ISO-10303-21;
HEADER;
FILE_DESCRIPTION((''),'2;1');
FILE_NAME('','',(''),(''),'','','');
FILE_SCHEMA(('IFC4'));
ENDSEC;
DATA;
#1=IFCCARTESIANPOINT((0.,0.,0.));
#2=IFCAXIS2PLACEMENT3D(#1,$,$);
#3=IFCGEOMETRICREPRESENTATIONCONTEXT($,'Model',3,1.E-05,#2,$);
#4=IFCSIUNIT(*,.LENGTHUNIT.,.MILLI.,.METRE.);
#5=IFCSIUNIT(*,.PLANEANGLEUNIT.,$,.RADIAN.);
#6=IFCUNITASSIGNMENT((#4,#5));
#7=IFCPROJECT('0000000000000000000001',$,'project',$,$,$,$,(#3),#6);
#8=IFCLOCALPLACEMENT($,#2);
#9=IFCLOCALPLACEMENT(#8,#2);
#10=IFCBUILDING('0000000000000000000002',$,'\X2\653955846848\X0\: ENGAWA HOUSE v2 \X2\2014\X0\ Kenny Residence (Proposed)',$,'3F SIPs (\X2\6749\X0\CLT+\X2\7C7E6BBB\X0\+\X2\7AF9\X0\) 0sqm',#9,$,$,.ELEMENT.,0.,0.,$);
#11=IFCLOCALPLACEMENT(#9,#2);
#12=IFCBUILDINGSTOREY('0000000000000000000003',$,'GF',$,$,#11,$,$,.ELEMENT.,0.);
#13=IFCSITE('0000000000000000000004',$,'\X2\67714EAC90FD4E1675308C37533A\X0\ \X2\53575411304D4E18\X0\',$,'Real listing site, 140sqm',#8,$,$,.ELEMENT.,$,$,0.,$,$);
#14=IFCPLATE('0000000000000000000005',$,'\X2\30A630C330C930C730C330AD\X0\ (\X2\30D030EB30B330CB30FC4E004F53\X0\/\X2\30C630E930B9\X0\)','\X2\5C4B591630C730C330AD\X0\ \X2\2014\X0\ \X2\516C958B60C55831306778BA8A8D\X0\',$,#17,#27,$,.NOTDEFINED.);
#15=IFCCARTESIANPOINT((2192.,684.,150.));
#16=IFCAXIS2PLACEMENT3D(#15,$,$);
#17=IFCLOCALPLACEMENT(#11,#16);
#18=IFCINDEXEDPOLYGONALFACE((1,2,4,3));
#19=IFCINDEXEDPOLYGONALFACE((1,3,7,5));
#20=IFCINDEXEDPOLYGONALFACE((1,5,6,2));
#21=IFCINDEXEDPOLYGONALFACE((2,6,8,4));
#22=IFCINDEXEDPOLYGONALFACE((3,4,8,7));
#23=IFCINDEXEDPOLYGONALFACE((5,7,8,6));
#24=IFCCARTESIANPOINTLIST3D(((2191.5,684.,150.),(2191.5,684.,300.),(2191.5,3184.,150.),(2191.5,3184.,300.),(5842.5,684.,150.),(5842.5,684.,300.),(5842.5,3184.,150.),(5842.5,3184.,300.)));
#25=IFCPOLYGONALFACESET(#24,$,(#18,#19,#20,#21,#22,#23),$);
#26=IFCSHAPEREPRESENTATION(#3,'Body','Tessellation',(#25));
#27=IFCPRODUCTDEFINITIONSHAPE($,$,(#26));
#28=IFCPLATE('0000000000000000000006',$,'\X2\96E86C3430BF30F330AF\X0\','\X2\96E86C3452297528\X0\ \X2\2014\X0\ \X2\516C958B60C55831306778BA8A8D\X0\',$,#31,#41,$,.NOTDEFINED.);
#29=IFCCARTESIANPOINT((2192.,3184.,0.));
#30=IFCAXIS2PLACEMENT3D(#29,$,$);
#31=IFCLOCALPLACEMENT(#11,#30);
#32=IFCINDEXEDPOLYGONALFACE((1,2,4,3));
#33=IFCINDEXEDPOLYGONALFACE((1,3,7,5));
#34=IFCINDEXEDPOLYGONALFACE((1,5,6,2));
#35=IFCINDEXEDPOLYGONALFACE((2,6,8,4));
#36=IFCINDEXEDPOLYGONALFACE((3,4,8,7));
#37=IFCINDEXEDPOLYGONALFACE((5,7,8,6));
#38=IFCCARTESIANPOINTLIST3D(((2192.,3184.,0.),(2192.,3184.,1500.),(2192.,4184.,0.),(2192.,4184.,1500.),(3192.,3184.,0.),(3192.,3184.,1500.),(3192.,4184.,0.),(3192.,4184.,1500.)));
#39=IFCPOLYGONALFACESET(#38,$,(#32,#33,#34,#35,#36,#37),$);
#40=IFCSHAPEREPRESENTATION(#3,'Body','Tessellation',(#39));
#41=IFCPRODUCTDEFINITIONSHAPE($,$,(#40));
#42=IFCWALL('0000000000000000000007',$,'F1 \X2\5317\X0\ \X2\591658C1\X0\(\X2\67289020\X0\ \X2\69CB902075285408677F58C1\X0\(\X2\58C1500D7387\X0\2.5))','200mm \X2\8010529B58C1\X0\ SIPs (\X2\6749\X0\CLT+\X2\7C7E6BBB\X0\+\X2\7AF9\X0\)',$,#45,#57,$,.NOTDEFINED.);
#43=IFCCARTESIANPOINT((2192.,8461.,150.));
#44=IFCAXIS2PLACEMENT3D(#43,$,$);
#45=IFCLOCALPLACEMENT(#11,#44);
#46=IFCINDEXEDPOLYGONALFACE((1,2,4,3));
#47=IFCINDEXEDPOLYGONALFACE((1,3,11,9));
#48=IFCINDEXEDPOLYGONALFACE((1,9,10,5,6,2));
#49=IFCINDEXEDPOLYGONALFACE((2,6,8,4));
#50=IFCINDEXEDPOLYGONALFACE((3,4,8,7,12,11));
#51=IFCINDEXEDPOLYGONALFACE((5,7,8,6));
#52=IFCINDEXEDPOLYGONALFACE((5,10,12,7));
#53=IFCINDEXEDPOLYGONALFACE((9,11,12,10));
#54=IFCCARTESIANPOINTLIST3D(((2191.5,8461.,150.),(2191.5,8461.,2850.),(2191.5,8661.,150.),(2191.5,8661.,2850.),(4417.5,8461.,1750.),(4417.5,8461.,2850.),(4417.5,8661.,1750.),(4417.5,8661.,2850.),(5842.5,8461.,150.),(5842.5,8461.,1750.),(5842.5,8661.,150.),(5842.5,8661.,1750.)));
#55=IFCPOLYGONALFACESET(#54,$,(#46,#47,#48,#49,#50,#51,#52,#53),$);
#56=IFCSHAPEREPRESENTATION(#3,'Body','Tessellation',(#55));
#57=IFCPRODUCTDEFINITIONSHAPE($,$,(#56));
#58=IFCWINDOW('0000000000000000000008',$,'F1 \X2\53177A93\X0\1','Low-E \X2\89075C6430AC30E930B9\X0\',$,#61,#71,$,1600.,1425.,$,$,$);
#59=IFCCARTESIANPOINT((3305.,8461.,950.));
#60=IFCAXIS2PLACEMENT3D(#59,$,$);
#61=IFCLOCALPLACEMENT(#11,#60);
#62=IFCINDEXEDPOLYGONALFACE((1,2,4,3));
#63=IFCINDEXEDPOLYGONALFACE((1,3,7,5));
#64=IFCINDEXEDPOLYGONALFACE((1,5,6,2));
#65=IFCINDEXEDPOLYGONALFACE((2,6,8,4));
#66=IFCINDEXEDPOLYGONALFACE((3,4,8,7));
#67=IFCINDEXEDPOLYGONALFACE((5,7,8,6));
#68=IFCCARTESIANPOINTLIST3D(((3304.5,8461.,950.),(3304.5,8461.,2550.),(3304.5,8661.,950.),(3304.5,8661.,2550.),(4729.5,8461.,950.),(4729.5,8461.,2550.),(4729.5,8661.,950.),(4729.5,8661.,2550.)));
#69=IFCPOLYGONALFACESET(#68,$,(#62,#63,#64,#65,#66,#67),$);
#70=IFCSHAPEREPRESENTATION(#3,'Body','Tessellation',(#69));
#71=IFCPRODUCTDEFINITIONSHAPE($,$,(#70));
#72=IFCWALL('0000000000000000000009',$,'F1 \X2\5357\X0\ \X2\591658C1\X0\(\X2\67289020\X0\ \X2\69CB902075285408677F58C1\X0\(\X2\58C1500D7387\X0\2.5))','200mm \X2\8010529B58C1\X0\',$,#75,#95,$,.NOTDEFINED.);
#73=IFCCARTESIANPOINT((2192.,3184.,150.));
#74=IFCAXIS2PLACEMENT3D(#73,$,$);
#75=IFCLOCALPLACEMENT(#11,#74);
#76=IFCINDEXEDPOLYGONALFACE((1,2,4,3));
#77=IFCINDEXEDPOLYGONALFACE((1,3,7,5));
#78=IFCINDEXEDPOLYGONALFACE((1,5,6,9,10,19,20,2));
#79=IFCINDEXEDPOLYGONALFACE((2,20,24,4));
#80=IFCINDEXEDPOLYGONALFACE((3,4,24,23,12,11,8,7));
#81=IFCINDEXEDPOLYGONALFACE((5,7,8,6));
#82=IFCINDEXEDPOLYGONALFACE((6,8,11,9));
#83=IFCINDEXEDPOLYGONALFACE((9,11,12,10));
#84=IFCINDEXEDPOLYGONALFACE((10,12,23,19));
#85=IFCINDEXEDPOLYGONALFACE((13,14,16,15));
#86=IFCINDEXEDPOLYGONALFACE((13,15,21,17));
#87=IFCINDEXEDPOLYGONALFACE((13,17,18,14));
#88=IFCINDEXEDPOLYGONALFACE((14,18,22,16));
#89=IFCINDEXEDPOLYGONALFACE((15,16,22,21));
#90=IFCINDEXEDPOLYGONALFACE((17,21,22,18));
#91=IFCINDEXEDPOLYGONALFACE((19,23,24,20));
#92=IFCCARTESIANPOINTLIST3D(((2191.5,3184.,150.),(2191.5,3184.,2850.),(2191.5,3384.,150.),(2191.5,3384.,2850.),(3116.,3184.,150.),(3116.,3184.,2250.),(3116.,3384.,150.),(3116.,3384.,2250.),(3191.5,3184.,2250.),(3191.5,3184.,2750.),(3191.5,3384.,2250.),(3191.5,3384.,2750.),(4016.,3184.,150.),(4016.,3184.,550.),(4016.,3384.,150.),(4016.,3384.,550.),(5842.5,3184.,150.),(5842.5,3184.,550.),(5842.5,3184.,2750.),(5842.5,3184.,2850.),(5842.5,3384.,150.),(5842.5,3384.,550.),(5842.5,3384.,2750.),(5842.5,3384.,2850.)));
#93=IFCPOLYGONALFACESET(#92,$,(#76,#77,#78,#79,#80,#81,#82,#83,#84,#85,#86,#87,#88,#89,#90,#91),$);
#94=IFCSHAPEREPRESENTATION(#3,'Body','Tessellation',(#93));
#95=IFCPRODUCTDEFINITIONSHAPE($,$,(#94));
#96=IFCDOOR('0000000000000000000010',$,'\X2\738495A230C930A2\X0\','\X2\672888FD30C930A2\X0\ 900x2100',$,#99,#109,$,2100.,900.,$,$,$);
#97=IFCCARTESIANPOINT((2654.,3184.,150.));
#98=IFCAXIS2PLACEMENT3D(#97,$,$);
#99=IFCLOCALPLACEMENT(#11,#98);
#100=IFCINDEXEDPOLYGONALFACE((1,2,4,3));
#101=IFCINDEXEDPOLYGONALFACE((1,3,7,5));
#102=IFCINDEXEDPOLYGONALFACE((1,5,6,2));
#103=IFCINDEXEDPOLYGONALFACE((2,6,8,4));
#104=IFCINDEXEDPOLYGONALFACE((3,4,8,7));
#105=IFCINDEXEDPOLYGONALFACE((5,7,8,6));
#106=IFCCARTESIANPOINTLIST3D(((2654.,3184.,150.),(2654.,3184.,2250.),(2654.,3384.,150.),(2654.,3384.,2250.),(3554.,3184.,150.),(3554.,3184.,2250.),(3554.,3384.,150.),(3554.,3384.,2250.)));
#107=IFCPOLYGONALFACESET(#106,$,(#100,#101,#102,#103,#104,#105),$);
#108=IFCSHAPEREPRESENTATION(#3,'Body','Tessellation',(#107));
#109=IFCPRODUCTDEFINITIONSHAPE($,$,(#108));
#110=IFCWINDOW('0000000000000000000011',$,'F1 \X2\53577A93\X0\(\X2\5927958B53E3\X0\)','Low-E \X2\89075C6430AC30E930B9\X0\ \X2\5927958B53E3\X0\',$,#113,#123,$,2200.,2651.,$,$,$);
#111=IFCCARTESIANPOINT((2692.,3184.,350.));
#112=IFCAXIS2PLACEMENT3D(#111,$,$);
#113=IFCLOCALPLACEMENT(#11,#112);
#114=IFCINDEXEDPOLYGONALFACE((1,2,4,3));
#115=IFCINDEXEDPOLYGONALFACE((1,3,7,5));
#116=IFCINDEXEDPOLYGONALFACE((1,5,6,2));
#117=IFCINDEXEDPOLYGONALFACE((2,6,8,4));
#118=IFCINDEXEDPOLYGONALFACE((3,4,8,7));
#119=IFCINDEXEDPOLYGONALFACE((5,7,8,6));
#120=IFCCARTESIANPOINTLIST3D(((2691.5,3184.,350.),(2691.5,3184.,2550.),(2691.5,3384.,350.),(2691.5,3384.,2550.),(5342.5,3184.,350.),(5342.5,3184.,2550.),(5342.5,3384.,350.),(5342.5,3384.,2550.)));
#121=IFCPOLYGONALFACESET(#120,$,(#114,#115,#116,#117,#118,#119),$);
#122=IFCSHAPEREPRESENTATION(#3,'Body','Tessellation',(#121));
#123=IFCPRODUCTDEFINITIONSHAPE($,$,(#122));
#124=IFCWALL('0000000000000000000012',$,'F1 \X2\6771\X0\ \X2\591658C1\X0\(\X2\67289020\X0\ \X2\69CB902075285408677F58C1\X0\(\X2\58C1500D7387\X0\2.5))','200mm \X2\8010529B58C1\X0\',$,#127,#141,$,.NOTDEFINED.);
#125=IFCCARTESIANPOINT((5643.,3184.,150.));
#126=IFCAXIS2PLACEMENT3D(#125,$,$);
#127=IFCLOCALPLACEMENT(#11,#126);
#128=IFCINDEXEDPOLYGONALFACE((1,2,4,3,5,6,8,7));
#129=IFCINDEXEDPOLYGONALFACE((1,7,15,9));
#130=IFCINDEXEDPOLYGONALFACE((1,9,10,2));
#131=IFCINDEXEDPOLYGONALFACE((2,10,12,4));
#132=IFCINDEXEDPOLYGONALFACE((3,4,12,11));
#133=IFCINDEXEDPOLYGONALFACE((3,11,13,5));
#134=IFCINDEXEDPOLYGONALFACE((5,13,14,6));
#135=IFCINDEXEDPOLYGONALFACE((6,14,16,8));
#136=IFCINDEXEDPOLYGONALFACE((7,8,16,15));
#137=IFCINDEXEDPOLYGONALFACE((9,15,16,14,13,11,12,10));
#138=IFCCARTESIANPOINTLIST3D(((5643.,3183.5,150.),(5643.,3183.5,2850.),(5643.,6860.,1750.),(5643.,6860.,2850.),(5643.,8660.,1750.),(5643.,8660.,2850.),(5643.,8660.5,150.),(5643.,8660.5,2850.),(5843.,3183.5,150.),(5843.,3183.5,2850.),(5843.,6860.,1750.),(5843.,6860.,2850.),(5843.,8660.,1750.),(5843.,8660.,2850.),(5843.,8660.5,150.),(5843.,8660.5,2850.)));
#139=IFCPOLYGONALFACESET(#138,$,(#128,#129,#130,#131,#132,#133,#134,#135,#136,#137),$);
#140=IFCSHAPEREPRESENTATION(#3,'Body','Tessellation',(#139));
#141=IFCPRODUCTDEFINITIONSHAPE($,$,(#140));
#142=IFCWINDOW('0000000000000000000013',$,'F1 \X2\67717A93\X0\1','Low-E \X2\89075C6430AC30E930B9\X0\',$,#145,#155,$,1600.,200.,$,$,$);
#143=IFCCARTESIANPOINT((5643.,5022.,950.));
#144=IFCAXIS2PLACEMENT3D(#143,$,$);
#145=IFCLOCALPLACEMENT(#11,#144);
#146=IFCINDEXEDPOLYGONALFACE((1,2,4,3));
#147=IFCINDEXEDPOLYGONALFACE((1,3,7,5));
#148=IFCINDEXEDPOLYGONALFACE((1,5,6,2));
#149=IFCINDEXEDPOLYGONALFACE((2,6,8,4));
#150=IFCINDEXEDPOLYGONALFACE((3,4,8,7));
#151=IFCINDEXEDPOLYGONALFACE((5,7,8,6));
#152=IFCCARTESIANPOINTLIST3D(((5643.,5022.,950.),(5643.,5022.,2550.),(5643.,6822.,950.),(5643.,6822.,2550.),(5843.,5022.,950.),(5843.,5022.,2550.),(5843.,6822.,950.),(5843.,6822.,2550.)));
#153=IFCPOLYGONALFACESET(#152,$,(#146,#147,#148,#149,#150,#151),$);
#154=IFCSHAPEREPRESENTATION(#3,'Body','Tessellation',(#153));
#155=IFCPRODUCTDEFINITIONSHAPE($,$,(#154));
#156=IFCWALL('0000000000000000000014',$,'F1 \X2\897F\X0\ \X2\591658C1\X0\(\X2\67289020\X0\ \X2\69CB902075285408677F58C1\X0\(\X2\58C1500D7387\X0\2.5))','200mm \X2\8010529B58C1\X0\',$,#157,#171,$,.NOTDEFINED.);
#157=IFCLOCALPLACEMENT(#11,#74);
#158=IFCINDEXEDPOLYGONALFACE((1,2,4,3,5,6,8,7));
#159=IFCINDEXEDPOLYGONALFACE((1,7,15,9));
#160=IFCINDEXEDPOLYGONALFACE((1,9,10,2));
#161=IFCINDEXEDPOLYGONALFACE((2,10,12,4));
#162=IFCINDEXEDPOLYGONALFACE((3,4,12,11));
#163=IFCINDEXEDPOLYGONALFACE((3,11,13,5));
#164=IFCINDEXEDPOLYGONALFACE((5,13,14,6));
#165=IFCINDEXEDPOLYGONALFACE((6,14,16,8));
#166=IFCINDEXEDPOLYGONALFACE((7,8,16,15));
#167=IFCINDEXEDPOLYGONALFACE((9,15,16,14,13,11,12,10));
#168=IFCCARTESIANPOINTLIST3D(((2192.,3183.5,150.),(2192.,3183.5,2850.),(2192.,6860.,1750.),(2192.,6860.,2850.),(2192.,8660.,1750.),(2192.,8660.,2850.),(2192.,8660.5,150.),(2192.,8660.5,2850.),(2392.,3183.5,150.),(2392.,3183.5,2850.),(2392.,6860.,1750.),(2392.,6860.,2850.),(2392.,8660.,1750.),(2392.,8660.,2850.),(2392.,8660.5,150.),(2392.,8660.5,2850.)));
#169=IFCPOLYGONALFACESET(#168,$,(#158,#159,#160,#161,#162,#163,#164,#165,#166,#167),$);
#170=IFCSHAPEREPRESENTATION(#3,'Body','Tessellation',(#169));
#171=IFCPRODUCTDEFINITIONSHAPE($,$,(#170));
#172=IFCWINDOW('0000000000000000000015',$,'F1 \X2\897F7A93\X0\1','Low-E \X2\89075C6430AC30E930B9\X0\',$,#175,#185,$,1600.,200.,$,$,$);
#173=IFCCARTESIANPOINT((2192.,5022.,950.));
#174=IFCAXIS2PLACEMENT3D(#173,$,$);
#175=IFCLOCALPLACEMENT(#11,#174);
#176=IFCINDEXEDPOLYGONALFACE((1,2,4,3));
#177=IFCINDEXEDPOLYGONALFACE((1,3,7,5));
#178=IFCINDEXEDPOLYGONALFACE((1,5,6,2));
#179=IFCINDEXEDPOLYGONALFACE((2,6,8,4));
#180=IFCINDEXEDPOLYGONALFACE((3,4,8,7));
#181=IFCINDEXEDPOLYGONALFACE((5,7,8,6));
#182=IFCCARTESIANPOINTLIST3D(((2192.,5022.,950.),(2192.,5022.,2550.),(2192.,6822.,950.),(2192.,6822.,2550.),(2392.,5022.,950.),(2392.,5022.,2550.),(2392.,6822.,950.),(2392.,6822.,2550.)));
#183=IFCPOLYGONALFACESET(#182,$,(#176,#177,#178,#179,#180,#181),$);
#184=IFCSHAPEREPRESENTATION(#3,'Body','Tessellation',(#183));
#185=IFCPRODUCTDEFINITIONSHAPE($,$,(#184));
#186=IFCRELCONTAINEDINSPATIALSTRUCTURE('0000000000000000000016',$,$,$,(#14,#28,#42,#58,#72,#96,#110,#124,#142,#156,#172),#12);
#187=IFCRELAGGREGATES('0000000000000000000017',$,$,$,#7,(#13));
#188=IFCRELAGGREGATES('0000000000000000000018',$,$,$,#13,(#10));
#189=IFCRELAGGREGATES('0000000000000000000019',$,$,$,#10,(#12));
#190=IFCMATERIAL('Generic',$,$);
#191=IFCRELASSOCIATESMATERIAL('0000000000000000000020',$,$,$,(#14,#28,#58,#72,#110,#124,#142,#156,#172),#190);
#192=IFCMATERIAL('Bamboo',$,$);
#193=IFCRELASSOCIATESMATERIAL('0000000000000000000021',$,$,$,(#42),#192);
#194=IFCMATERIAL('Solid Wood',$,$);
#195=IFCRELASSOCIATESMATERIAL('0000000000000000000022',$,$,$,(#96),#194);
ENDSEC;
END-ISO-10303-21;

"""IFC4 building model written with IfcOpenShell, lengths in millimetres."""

from ifc_helpers import new_model, si_unit, frame, frame_2d, origin, place, context, project, spatial, rectangle, extrude, material, element, fill, save


model = new_model("IFC4")

# Units and contexts
model_context = context("Model", 3, precision=1e-05, world=origin())
ifc_project = project(units=[si_unit("LENGTHUNIT", "METRE", prefix="MILLI"), si_unit("PLANEANGLEUNIT", "RADIAN")], contexts=[model_context])

# Site, building, storey
site_placement = place(None, origin())
site = spatial("IfcSite", under=ifc_project, at=site_placement, Name="東京都世田谷区 南向き丘", ObjectType="Real listing site, 140sqm", CompositionType="ELEMENT", RefElevation=0.0)
building_placement = place(site_placement, origin())
building = spatial("IfcBuilding", under=site, at=building_placement, Name="改善案: ENGAWA HOUSE v2 — Kenny Residence (Proposed)", ObjectType="3F SIPs (杉CLT+籾殻+竹) 0sqm", CompositionType="ELEMENT", ElevationOfRefHeight=0.0, ElevationOfTerrain=0.0)
storey_placement = place(building_placement, origin())
storey = spatial("IfcBuildingStorey", under=building, at=storey_placement, Name="GF", CompositionType="ELEMENT", Elevation=0.0)

# Shared definitions
ifc_material_1 = material(Name="Generic")

# Plates
plate_1_placement = place(storey_placement, frame((2192.0, 684.0, 150.0)))
element("IfcPlate", 1, at=plate_1_placement, inside=storey, material=ifc_material_1, Name="ウッドデッキ (バルコニー一体/テラス)", Description="屋外デッキ — 公開情報で確認", PredefinedType="NOTDEFINED", context=model_context, shape_type="SweptSolid", body=[
    extrude(rectangle(XDim=3651.0, YDim=2500.0, at=frame_2d((1825.0, 1250.0))), frame((2192.0, 684.0, 150.0)), (0.0, 0.0, 1.0), 150.0),
])
plate_2_placement = place(storey_placement, frame((2192.0, 3184.0, 0.0)))
element("IfcPlate", 2, at=plate_2_placement, inside=storey, material=ifc_material_1, Name="雨水タンク", Description="雨水利用 — 公開情報で確認", PredefinedType="NOTDEFINED", context=model_context, shape_type="SweptSolid", body=[
    extrude(rectangle(XDim=1000.0, YDim=1000.0, at=frame_2d((500.0, 500.0))), frame((2192.0, 3184.0, 0.0)), (0.0, 0.0, 1.0), 1500.0),
])

# Wall, opening, window
ifc_material_2 = material(Name="Bamboo")
wall_1_placement = place(storey_placement, frame((2192.0, 8461.0, 150.0)))
wall_1 = element("IfcWall", 3, at=wall_1_placement, inside=storey, material=ifc_material_2, Name="F1 北 外壁(木造 構造用合板壁(壁倍率2.5))", Description="200mm 耐力壁 SIPs (杉CLT+籾殻+竹)", PredefinedType="NOTDEFINED", context=model_context, shape_type="SweptSolid", body=[
    extrude(rectangle(XDim=3651.0, YDim=200.0, at=frame_2d((1825.0, 100.0))), frame((2192.0, 8461.0, 150.0)), (0.0, 0.0, 1.0), 2700.0),
])
opening_1_placement = place(storey_placement, frame((3305.0, 8461.0, 950.0)))
opening_1 = element("IfcOpeningElement", 4, at=opening_1_placement, cuts=wall_1, PredefinedType="NOTDEFINED", context=model_context, shape_type="SweptSolid", body=[
    extrude(rectangle(XDim=1425.0, YDim=200.0, at=frame_2d((712.0, 100.0))), frame((3305.0, 8461.0, 950.0)), (0.0, 0.0, 1.0), 1600.0),
])
window_1_placement = place(storey_placement, frame((3305.0, 8461.0, 950.0)))
window_1 = element("IfcWindow", 5, at=window_1_placement, inside=storey, material=ifc_material_1, Name="F1 北窓1", Description="Low-E 複層ガラス", OverallHeight=1600.0, OverallWidth=1425.0, context=model_context, shape_type="SweptSolid", body=[
    extrude(rectangle(XDim=1425.0, YDim=200.0, at=frame_2d((712.0, 100.0))), frame((3305.0, 8461.0, 950.0)), (0.0, 0.0, 1.0), 1600.0),
])
fill(opening_1, window_1)

# Wall, openings, door, window
wall_2_placement = place(storey_placement, frame((2192.0, 3184.0, 150.0)))
wall_2 = element("IfcWall", 6, at=wall_2_placement, inside=storey, material=ifc_material_1, Name="F1 南 外壁(木造 構造用合板壁(壁倍率2.5))", Description="200mm 耐力壁", PredefinedType="NOTDEFINED", context=model_context, shape_type="SweptSolid", body=[
    extrude(rectangle(XDim=3651.0, YDim=200.0, at=frame_2d((1825.0, 100.0))), frame((2192.0, 3184.0, 150.0)), (0.0, 0.0, 1.0), 2700.0),
])
opening_2_placement = place(storey_placement, frame((2654.0, 3184.0, 150.0)))
opening_2 = element("IfcOpeningElement", 7, at=opening_2_placement, cuts=wall_2, PredefinedType="NOTDEFINED", context=model_context, shape_type="SweptSolid", body=[
    extrude(rectangle(XDim=900.0, YDim=200.0, at=frame_2d((450.0, 100.0))), frame((2654.0, 3184.0, 150.0)), (0.0, 0.0, 1.0), 2100.0),
])
opening_3_placement = place(storey_placement, frame((2692.0, 3184.0, 350.0)))
opening_3 = element("IfcOpeningElement", 8, at=opening_3_placement, cuts=wall_2, PredefinedType="NOTDEFINED", context=model_context, shape_type="SweptSolid", body=[
    extrude(rectangle(XDim=2651.0, YDim=200.0, at=frame_2d((1325.0, 100.0))), frame((2692.0, 3184.0, 350.0)), (0.0, 0.0, 1.0), 2200.0),
])
ifc_material_3 = material(Name="Solid Wood")
door_placement = place(storey_placement, frame((2654.0, 3184.0, 150.0)))
door = element("IfcDoor", 9, at=door_placement, inside=storey, material=ifc_material_3, Name="玄関ドア", Description="木製ドア 900x2100", OverallHeight=2100.0, OverallWidth=900.0, context=model_context, shape_type="SweptSolid", body=[
    extrude(rectangle(XDim=900.0, YDim=200.0, at=frame_2d((450.0, 100.0))), frame((2654.0, 3184.0, 150.0)), (0.0, 0.0, 1.0), 2100.0),
])
fill(opening_2, door)
window_2_placement = place(storey_placement, frame((2692.0, 3184.0, 350.0)))
window_2 = element("IfcWindow", 10, at=window_2_placement, inside=storey, material=ifc_material_1, Name="F1 南窓(大開口)", Description="Low-E 複層ガラス 大開口", OverallHeight=2200.0, OverallWidth=2651.0, context=model_context, shape_type="SweptSolid", body=[
    extrude(rectangle(XDim=2651.0, YDim=200.0, at=frame_2d((1325.0, 100.0))), frame((2692.0, 3184.0, 350.0)), (0.0, 0.0, 1.0), 2200.0),
])
fill(opening_3, window_2)

# Walls, openings, windows
wall_3_placement = place(storey_placement, frame((5643.0, 3184.0, 150.0)))
wall_3 = element("IfcWall", 11, at=wall_3_placement, inside=storey, material=ifc_material_1, Name="F1 東 外壁(木造 構造用合板壁(壁倍率2.5))", Description="200mm 耐力壁", PredefinedType="NOTDEFINED", context=model_context, shape_type="SweptSolid", body=[
    extrude(rectangle(XDim=200.0, YDim=5477.0, at=frame_2d((100.0, 2738.0))), frame((5643.0, 3184.0, 150.0)), (0.0, 0.0, 1.0), 2700.0),
])
opening_4_placement = place(storey_placement, frame((5643.0, 5022.0, 950.0)))
opening_4 = element("IfcOpeningElement", 12, at=opening_4_placement, cuts=wall_3, PredefinedType="NOTDEFINED", context=model_context, shape_type="SweptSolid", body=[
    extrude(rectangle(XDim=200.0, YDim=1800.0, at=frame_2d((100.0, 900.0))), frame((5643.0, 5022.0, 950.0)), (0.0, 0.0, 1.0), 1600.0),
])
window_3_placement = place(storey_placement, frame((5643.0, 5022.0, 950.0)))
window_3 = element("IfcWindow", 13, at=window_3_placement, inside=storey, material=ifc_material_1, Name="F1 東窓1", Description="Low-E 複層ガラス", OverallHeight=1600.0, OverallWidth=200.0, context=model_context, shape_type="SweptSolid", body=[
    extrude(rectangle(XDim=200.0, YDim=1800.0, at=frame_2d((100.0, 900.0))), frame((5643.0, 5022.0, 950.0)), (0.0, 0.0, 1.0), 1600.0),
])
fill(opening_4, window_3)
wall_4_placement = place(storey_placement, frame((2192.0, 3184.0, 150.0)))
wall_4 = element("IfcWall", 14, at=wall_4_placement, inside=storey, material=ifc_material_1, Name="F1 西 外壁(木造 構造用合板壁(壁倍率2.5))", Description="200mm 耐力壁", PredefinedType="NOTDEFINED", context=model_context, shape_type="SweptSolid", body=[
    extrude(rectangle(XDim=200.0, YDim=5477.0, at=frame_2d((100.0, 2738.0))), frame((2192.0, 3184.0, 150.0)), (0.0, 0.0, 1.0), 2700.0),
])
opening_5_placement = place(storey_placement, frame((2192.0, 5022.0, 950.0)))
opening_5 = element("IfcOpeningElement", 15, at=opening_5_placement, cuts=wall_4, PredefinedType="NOTDEFINED", context=model_context, shape_type="SweptSolid", body=[
    extrude(rectangle(XDim=200.0, YDim=1800.0, at=frame_2d((100.0, 900.0))), frame((2192.0, 5022.0, 950.0)), (0.0, 0.0, 1.0), 1600.0),
])
window_4_placement = place(storey_placement, frame((2192.0, 5022.0, 950.0)))
window_4 = element("IfcWindow", 16, at=window_4_placement, inside=storey, material=ifc_material_1, Name="F1 西窓1", Description="Low-E 複層ガラス", OverallHeight=1600.0, OverallWidth=200.0, context=model_context, shape_type="SweptSolid", body=[
    extrude(rectangle(XDim=200.0, YDim=1800.0, at=frame_2d((100.0, 900.0))), frame((2192.0, 5022.0, 950.0)), (0.0, 0.0, 1.0), 1600.0),
])
fill(opening_5, window_4)

save(model, "model.ifc")
